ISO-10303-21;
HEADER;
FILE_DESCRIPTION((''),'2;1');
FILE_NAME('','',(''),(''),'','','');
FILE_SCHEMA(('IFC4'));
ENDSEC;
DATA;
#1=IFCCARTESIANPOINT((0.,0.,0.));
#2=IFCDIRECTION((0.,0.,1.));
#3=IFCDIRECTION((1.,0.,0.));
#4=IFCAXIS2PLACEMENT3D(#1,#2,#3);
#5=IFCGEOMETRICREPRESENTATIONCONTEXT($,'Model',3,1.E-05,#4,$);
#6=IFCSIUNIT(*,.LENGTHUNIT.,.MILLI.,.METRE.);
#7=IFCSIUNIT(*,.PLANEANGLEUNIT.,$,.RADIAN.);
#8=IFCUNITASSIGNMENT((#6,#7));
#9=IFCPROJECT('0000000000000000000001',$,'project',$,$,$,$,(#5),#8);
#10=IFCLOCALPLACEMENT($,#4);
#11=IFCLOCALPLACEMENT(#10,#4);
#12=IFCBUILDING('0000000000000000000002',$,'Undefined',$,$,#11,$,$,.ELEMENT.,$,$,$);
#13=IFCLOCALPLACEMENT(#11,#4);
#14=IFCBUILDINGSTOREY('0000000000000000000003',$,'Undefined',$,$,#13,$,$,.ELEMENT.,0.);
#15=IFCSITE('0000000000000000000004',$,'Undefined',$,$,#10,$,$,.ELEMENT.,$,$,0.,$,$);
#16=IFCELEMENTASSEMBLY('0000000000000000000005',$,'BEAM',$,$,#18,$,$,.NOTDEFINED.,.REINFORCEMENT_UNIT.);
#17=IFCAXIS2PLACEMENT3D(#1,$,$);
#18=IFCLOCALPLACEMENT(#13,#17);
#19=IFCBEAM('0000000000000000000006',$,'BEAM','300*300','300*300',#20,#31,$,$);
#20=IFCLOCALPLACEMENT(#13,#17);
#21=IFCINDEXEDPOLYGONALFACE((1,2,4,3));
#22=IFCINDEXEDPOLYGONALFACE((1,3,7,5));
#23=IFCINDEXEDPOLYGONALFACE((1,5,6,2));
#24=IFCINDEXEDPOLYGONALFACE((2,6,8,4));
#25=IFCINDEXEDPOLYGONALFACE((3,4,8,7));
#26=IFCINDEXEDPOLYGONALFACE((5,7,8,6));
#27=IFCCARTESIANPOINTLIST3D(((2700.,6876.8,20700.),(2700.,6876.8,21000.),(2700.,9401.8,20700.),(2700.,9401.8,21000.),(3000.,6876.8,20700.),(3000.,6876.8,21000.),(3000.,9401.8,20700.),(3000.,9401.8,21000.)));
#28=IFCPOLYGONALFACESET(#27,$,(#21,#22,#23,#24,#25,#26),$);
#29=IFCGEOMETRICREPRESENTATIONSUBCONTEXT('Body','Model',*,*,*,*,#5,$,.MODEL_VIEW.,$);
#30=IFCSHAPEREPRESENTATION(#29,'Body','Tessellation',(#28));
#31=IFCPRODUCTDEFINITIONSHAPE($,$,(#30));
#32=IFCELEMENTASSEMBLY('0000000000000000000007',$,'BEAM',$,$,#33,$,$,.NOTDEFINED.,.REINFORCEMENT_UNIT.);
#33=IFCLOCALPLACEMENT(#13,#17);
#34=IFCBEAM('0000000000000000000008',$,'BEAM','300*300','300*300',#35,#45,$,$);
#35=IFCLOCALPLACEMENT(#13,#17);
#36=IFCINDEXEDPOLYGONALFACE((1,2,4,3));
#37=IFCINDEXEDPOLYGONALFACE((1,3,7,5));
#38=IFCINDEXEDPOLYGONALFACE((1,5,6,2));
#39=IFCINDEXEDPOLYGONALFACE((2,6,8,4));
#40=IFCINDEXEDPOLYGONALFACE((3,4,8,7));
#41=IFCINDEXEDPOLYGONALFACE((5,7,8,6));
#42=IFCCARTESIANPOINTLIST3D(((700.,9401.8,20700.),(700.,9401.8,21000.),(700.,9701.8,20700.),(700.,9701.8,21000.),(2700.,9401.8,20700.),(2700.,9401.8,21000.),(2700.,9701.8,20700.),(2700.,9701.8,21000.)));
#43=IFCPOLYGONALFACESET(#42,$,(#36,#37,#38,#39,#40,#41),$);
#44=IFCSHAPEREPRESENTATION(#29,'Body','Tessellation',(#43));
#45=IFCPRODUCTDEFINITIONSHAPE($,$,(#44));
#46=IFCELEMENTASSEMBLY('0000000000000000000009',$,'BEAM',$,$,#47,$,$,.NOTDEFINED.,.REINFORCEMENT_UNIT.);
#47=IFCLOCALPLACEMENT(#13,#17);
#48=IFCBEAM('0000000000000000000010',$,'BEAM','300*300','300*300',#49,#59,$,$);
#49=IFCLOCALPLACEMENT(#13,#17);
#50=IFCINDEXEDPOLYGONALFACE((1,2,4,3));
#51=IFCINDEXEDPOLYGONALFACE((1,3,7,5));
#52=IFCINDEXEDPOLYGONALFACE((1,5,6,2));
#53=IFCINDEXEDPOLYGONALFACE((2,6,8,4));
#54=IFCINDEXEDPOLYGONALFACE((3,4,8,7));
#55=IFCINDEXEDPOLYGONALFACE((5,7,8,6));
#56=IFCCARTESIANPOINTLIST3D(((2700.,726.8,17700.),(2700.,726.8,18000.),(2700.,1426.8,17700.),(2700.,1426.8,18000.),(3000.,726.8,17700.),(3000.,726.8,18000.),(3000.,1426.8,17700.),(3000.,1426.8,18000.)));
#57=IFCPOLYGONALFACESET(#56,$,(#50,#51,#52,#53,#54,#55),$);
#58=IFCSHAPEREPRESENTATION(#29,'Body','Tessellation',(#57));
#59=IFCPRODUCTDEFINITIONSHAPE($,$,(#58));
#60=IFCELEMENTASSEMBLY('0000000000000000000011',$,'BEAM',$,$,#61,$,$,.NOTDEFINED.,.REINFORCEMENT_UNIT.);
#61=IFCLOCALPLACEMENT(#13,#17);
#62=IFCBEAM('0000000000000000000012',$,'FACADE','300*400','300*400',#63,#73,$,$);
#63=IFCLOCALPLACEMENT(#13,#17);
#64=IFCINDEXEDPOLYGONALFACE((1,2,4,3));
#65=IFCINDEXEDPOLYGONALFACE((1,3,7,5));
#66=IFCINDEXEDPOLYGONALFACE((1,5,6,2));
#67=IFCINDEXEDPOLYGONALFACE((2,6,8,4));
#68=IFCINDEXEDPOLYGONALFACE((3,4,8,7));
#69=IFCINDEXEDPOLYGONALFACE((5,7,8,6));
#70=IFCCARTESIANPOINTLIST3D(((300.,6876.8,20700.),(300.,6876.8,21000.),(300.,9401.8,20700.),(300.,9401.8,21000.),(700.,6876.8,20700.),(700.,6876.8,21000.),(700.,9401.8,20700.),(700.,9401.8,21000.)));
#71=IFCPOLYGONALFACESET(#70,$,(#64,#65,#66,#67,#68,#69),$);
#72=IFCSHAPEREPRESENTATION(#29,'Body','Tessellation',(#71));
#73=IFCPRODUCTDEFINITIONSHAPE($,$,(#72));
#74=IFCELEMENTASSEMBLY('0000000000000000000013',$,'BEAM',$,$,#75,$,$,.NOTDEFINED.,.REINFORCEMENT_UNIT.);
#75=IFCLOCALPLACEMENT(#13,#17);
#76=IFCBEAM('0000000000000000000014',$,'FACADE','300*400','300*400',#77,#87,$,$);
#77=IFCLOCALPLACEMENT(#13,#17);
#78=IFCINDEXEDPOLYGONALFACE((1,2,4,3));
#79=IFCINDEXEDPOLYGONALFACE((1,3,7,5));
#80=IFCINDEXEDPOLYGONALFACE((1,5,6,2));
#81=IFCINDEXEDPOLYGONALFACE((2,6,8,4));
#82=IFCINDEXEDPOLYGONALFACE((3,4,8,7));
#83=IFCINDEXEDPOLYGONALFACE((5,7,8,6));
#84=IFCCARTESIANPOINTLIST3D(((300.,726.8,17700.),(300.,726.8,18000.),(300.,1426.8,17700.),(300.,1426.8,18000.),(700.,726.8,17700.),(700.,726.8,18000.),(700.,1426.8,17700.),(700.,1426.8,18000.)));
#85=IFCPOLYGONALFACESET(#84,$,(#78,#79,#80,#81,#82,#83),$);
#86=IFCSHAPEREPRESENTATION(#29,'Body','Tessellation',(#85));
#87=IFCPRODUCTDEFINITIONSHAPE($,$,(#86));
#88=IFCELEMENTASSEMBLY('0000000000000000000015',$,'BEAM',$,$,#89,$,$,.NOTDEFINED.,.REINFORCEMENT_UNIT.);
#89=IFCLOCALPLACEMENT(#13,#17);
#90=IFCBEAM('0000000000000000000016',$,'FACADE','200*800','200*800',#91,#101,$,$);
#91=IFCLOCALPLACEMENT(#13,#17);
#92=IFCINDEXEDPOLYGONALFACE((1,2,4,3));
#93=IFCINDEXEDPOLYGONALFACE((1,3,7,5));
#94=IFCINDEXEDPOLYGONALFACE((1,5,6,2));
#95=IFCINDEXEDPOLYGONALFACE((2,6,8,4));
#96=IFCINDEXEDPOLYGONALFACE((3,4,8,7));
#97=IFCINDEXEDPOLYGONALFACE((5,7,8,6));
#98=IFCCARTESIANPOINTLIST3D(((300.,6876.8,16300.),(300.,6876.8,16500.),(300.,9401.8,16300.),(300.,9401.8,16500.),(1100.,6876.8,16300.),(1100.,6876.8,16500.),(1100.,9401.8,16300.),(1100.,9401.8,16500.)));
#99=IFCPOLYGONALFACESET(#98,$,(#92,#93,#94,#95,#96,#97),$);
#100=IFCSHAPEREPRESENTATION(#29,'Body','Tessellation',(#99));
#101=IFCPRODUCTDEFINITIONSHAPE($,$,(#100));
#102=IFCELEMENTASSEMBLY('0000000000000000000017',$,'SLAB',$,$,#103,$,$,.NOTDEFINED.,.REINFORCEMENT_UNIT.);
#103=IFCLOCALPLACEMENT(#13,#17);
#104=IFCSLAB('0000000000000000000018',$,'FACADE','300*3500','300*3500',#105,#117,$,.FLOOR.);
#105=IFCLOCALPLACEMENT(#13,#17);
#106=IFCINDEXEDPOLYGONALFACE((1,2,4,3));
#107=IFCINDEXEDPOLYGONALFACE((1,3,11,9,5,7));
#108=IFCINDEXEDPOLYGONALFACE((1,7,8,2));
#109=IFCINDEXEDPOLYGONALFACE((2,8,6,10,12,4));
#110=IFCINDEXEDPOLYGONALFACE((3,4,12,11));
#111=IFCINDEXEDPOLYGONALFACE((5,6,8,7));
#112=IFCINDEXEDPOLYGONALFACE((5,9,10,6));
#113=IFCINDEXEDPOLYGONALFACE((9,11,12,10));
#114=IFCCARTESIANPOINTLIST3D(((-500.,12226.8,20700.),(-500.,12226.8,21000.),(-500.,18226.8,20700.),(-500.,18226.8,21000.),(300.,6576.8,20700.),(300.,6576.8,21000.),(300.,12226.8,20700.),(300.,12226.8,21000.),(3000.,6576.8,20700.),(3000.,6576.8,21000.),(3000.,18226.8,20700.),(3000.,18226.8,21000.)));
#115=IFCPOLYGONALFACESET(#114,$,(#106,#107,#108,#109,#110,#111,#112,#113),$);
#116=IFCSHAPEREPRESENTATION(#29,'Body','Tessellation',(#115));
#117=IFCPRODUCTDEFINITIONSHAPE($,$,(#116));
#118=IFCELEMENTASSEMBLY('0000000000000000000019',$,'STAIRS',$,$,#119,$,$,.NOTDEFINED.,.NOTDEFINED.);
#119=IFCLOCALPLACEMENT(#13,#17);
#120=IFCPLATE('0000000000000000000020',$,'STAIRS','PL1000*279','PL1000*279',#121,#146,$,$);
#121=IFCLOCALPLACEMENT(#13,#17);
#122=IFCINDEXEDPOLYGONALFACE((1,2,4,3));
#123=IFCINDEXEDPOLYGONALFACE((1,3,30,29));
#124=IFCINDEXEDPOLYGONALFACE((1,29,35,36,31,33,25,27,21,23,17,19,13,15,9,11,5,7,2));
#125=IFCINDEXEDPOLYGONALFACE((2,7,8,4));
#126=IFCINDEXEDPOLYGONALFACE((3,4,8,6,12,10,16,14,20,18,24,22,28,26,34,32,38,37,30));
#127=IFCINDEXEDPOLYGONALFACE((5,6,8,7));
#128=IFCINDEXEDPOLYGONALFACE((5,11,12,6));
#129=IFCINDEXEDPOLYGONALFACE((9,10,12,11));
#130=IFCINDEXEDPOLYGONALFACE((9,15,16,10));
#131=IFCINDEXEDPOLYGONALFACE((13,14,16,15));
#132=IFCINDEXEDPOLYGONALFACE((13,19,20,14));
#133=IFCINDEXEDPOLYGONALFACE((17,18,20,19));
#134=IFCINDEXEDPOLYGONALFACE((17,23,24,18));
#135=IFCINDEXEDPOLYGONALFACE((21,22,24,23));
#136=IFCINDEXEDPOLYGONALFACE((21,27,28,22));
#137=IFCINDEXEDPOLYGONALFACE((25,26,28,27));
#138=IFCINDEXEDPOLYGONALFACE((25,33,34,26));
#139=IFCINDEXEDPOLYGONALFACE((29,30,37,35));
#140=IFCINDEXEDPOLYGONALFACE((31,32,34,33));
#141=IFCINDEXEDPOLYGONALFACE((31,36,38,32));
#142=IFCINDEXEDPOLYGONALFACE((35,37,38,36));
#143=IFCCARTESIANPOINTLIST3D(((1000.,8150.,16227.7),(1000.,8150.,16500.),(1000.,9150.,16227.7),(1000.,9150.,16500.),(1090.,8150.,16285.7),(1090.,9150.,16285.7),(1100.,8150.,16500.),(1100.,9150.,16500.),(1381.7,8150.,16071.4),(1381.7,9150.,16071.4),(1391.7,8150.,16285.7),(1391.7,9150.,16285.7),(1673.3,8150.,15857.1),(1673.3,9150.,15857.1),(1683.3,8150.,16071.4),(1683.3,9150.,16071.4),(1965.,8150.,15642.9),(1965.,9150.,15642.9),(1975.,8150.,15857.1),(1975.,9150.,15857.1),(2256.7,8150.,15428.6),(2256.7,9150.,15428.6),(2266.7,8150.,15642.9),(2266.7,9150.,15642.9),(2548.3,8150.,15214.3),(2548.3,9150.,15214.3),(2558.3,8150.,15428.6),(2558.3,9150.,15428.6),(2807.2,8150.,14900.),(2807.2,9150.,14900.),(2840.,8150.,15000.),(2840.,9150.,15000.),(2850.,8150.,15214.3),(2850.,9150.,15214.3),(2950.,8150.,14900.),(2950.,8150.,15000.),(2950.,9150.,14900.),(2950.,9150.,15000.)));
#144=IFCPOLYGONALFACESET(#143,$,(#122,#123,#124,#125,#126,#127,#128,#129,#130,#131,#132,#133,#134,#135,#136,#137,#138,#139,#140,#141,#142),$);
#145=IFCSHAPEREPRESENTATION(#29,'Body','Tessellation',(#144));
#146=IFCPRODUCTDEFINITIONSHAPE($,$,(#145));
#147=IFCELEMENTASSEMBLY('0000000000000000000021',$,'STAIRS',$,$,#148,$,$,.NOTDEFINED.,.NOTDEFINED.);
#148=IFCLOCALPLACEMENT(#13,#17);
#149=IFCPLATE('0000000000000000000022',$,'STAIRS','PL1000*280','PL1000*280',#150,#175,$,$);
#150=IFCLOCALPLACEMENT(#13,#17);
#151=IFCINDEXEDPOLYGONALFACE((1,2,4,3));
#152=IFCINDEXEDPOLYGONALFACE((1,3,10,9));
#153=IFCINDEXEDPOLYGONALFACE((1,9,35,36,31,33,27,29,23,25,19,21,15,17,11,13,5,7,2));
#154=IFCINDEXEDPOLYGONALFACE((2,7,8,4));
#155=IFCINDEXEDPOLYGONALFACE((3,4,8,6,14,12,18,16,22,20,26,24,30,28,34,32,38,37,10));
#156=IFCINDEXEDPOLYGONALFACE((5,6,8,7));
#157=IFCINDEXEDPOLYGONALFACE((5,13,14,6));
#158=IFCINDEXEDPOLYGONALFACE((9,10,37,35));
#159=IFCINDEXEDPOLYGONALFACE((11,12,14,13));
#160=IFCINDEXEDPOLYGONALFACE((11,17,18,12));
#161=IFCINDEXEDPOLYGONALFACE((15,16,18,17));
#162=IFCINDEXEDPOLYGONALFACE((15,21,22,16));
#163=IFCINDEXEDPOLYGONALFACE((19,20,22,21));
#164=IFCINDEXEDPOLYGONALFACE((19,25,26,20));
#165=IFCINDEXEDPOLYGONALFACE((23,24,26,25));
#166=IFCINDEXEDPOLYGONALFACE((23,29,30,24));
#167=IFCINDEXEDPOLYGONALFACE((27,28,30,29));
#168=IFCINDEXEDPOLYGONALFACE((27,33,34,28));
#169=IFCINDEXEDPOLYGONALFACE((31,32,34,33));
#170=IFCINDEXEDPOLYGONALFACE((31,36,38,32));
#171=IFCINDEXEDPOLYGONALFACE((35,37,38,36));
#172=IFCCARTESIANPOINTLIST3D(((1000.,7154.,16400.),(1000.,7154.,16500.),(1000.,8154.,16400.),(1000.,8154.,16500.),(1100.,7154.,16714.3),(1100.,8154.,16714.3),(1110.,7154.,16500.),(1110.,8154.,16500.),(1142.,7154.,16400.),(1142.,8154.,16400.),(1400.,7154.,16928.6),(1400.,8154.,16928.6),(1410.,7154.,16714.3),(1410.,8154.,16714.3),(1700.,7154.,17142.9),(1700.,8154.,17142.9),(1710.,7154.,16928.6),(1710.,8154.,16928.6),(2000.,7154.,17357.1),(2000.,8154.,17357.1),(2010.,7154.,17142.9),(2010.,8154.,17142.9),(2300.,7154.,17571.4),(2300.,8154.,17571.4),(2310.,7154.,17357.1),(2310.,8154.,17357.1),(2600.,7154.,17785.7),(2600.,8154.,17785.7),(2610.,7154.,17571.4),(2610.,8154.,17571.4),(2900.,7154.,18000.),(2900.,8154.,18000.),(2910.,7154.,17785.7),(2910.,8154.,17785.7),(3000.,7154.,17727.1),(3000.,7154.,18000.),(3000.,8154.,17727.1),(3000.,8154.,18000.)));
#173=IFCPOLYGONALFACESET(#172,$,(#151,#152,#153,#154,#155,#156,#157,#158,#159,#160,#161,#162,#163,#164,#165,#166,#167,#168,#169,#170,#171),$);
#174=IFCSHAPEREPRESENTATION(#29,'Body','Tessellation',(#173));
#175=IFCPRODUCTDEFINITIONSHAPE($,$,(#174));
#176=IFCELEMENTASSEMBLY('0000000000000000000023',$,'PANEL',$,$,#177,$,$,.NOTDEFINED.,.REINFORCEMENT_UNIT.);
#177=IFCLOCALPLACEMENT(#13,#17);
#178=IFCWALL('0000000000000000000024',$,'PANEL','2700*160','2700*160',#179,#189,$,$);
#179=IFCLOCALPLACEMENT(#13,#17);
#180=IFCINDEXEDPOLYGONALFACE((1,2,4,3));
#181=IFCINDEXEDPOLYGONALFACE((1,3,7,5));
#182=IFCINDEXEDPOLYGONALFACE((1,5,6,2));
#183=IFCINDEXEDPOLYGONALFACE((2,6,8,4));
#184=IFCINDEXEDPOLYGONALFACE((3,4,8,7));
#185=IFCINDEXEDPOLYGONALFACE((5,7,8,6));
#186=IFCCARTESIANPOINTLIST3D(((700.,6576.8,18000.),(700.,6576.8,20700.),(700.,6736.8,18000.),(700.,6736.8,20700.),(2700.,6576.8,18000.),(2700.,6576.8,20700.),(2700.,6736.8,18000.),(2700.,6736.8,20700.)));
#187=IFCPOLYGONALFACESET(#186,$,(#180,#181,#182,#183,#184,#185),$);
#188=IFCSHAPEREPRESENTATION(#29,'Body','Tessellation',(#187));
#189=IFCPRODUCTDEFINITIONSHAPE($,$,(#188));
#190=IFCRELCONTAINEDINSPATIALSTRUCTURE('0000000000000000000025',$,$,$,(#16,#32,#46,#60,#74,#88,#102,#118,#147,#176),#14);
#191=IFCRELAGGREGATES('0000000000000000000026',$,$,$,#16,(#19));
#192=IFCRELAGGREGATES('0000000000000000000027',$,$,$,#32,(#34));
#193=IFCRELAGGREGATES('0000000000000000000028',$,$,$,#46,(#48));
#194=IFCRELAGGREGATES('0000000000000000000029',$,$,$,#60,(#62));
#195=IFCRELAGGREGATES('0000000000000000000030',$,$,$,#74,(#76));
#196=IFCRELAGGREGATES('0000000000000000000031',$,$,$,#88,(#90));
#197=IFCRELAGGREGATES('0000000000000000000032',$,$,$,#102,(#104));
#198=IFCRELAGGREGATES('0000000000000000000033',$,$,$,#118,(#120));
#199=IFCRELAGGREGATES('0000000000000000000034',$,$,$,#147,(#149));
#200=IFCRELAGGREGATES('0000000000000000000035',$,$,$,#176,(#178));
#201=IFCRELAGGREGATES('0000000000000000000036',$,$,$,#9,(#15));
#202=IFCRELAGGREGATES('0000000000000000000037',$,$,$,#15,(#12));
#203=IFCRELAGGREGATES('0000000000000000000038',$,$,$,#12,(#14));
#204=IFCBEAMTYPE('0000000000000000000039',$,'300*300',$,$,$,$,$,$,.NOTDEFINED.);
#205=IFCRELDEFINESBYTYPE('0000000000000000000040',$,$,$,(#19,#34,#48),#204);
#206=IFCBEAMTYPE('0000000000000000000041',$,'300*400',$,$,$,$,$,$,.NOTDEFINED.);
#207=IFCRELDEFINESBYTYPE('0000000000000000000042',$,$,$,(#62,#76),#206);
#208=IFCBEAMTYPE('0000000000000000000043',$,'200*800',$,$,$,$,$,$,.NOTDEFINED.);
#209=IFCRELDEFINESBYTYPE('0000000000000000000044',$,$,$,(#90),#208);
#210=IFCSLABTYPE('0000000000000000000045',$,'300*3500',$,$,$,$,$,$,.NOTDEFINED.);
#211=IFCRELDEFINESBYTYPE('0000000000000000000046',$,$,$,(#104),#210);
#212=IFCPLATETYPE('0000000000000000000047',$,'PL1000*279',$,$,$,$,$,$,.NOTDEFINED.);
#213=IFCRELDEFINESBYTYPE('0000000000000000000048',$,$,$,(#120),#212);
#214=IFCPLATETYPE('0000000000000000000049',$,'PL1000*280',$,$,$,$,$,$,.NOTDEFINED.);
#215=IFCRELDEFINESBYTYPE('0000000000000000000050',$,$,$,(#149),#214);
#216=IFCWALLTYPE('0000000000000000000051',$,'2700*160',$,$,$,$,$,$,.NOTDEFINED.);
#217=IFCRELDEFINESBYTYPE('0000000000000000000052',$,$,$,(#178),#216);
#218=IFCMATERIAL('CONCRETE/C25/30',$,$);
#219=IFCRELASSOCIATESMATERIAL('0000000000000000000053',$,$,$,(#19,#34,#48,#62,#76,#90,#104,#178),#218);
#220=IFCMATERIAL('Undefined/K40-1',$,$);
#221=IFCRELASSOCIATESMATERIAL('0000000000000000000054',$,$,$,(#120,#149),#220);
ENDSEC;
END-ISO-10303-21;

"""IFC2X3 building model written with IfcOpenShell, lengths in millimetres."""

from ifc_helpers import new_model, si_unit, frame, frame_2d, origin_with_axes, origin_2d_with_axis, place, context, subcontext, project, spatial, polyline, rectangle, outline, extrude, material, type_object, element, aggregate, save


model = new_model("IFC2X3")

# Units and contexts
model_context = context("Model", 3, precision=1e-05, world=origin_with_axes())
body_context = subcontext(model_context, "Body", "Model", "MODEL_VIEW")
ifc_project = project(units=[si_unit("LENGTHUNIT", "METRE", prefix="MILLI"), si_unit("PLANEANGLEUNIT", "RADIAN")], contexts=[model_context])

# Site, building, storey
site_placement = place(None, origin_with_axes())
site = spatial("IfcSite", under=ifc_project, at=site_placement, Name="Undefined", CompositionType="ELEMENT", RefElevation=0.0)
building_placement = place(site_placement, origin_with_axes())
building = spatial("IfcBuilding", under=site, at=building_placement, Name="Undefined", CompositionType="ELEMENT")
storey_placement = place(building_placement, origin_with_axes())
storey = spatial("IfcBuildingStorey", under=building, at=storey_placement, Name="Undefined", CompositionType="ELEMENT", Elevation=0.0)

# Shared definitions
ifc_material_1 = material(Name="CONCRETE/C25/30")

# Element assemblies, beams
beam_type_1 = type_object("IfcBeamType", Name="300*300", PredefinedType="NOTDEFINED")
assembly_1_placement = place(storey_placement, origin_with_axes())
assembly_1 = element("IfcElementAssembly", 1, at=assembly_1_placement, inside=storey, Name="BEAM", AssemblyPlace="NOTDEFINED", PredefinedType="REINFORCEMENT_UNIT")
beam_1_placement = place(assembly_1_placement, frame((2850.0, 9401.8, 20850.0), z_axis=(0.0, 0.0, 1.0), x_axis=(0.0, -1.0, 0.0)))
beam_1 = element("IfcBeam", 2, at=beam_1_placement, type_object=beam_type_1, material=ifc_material_1, Name="BEAM", Description="300*300", ObjectType="300*300", context=body_context, shape_type="SweptSolid", body=[
    extrude(rectangle(XDim=300.0, YDim=300.0, at=origin_2d_with_axis()), frame((2525.0, 0.0, 0.0), z_axis=(-1.0, 0.0, 0.0), x_axis=(0.0, -1.0, 0.0)), (0.0, 0.0, 1.0), 2525.0),
])
aggregate(assembly_1, [beam_1])
assembly_2_placement = place(storey_placement, origin_with_axes())
assembly_2 = element("IfcElementAssembly", 3, at=assembly_2_placement, inside=storey, Name="BEAM", AssemblyPlace="NOTDEFINED", PredefinedType="REINFORCEMENT_UNIT")
beam_2_placement = place(assembly_2_placement, frame((2700.0, 9551.8, 20850.0), z_axis=(0.0, 0.0, 1.0), x_axis=(-1.0, 0.0, 0.0)))
beam_2 = element("IfcBeam", 4, at=beam_2_placement, type_object=beam_type_1, material=ifc_material_1, Name="BEAM", Description="300*300", ObjectType="300*300", context=body_context, shape_type="SweptSolid", body=[
    extrude(rectangle(XDim=300.0, YDim=300.0, at=origin_2d_with_axis()), frame((2000.0, 0.0, 0.0), z_axis=(-1.0, 0.0, 0.0), x_axis=(0.0, -1.0, 0.0)), (0.0, 0.0, 1.0), 2000.0),
])
aggregate(assembly_2, [beam_2])
assembly_3_placement = place(storey_placement, origin_with_axes())
assembly_3 = element("IfcElementAssembly", 5, at=assembly_3_placement, inside=storey, Name="BEAM", AssemblyPlace="NOTDEFINED", PredefinedType="REINFORCEMENT_UNIT")
beam_3_placement = place(assembly_3_placement, frame((2850.0, 1426.8, 17850.0), z_axis=(0.0, 0.0, 1.0), x_axis=(0.0, -1.0, 0.0)))
beam_3 = element("IfcBeam", 6, at=beam_3_placement, type_object=beam_type_1, material=ifc_material_1, Name="BEAM", Description="300*300", ObjectType="300*300", context=body_context, shape_type="SweptSolid", body=[
    extrude(rectangle(XDim=300.0, YDim=300.0, at=origin_2d_with_axis()), frame((700.0, 0.0, 0.0), z_axis=(-1.0, 0.0, 0.0), x_axis=(0.0, -1.0, 0.0)), (0.0, 0.0, 1.0), 700.0),
])
aggregate(assembly_3, [beam_3])
assembly_4_placement = place(storey_placement, origin_with_axes())
assembly_4 = element("IfcElementAssembly", 7, at=assembly_4_placement, inside=storey, Name="BEAM", AssemblyPlace="NOTDEFINED", PredefinedType="REINFORCEMENT_UNIT")
beam_type_2 = type_object("IfcBeamType", Name="300*400", PredefinedType="NOTDEFINED")
beam_4_placement = place(assembly_4_placement, frame((500.0, 9401.8, 20850.0), z_axis=(0.0, 0.0, 1.0), x_axis=(0.0, -1.0, 0.0)))
beam_4 = element("IfcBeam", 8, at=beam_4_placement, type_object=beam_type_2, material=ifc_material_1, Name="FACADE", Description="300*400", ObjectType="300*400", context=body_context, shape_type="SweptSolid", body=[
    extrude(rectangle(XDim=400.0, YDim=300.0, at=origin_2d_with_axis()), frame((2525.0, 0.0, 0.0), z_axis=(-1.0, 0.0, 0.0), x_axis=(0.0, -1.0, 0.0)), (0.0, 0.0, 1.0), 2525.0),
])
aggregate(assembly_4, [beam_4])
assembly_5_placement = place(storey_placement, origin_with_axes())
assembly_5 = element("IfcElementAssembly", 9, at=assembly_5_placement, inside=storey, Name="BEAM", AssemblyPlace="NOTDEFINED", PredefinedType="REINFORCEMENT_UNIT")
beam_5_placement = place(assembly_5_placement, frame((500.0, 1426.8, 17850.0), z_axis=(0.0, 0.0, 1.0), x_axis=(0.0, -1.0, 0.0)))
beam_5 = element("IfcBeam", 10, at=beam_5_placement, type_object=beam_type_2, material=ifc_material_1, Name="FACADE", Description="300*400", ObjectType="300*400", context=body_context, shape_type="SweptSolid", body=[
    extrude(rectangle(XDim=400.0, YDim=300.0, at=origin_2d_with_axis()), frame((700.0, 0.0, 0.0), z_axis=(-1.0, 0.0, 0.0), x_axis=(0.0, -1.0, 0.0)), (0.0, 0.0, 1.0), 700.0),
])
aggregate(assembly_5, [beam_5])
assembly_6_placement = place(storey_placement, origin_with_axes())
assembly_6 = element("IfcElementAssembly", 11, at=assembly_6_placement, inside=storey, Name="BEAM", AssemblyPlace="NOTDEFINED", PredefinedType="REINFORCEMENT_UNIT")
beam_type_3 = type_object("IfcBeamType", Name="200*800", PredefinedType="NOTDEFINED")
beam_6_placement = place(assembly_6_placement, frame((700.0, 9401.8, 16400.0), z_axis=(0.0, 0.0, 1.0), x_axis=(0.0, -1.0, 0.0)))
beam_6 = element("IfcBeam", 12, at=beam_6_placement, type_object=beam_type_3, material=ifc_material_1, Name="FACADE", Description="200*800", ObjectType="200*800", context=body_context, shape_type="SweptSolid", body=[
    extrude(rectangle(XDim=800.0, YDim=200.0, at=origin_2d_with_axis()), frame((2525.0, 0.0, 0.0), z_axis=(-1.0, 0.0, 0.0), x_axis=(0.0, -1.0, 0.0)), (0.0, 0.0, 1.0), 2525.0),
])
aggregate(assembly_6, [beam_6])

# Element assembly, slab
assembly_7_placement = place(storey_placement, origin_with_axes())
assembly_7 = element("IfcElementAssembly", 13, at=assembly_7_placement, inside=storey, Name="SLAB", AssemblyPlace="NOTDEFINED", PredefinedType="REINFORCEMENT_UNIT")
slab_type = type_object("IfcSlabType", Name="300*3500", PredefinedType="NOTDEFINED")
slab_placement = place(assembly_7_placement, frame((300.0, 6576.8, 20850.0), z_axis=(0.0, 0.0, 1.0), x_axis=(1.0, 0.0, 0.0)))
slab = element("IfcSlab", 14, at=slab_placement, type_object=slab_type, material=ifc_material_1, Name="FACADE", Description="300*3500", ObjectType="300*3500", PredefinedType="FLOOR", context=body_context, shape_type="SweptSolid", body=[
    extrude(outline(polyline([(0.0, 0.0), (2700.0, 0.0), (2700.0, 11650.0), (-800.0, 11650.0), (-800.0, 5650.0), (0.0, 5650.0), (0.0, 0.0), (0.0, 0.0)])), frame((0.0, 0.0, -150.0), z_axis=(0.0, 0.0, 1.0), x_axis=(1.0, 0.0, 0.0)), (0.0, 0.0, 1.0), 300.0),
])
aggregate(assembly_7, [slab])

# Element assemblies, plates
assembly_8_placement = place(storey_placement, origin_with_axes())
assembly_8 = element("IfcElementAssembly", 15, at=assembly_8_placement, inside=storey, Name="STAIRS", AssemblyPlace="NOTDEFINED", PredefinedType="NOTDEFINED")
ifc_material_2 = material(Name="Undefined/K40-1")
plate_type_1 = type_object("IfcPlateType", Name="PL1000*279", PredefinedType="NOTDEFINED")
plate_1_placement = place(assembly_8_placement, frame((2840.0, 8650.0, 15000.0), z_axis=(0.0, 1.0, 0.0), x_axis=(1.0, 0.0, 0.0)))
plate_1 = element("IfcPlate", 16, at=plate_1_placement, type_object=plate_type_1, material=ifc_material_2, Name="STAIRS", Description="PL1000*279", ObjectType="PL1000*279", context=body_context, shape_type="SweptSolid", body=[
    extrude(outline(polyline([(0.0, 0.0), (110.0, 0.0), (110.0, 100.0), (-32.8, 100.0), (-1840.0, -1227.7), (-1840.0, -1500.0), (-1740.0, -1500.0), (-1750.0, -1285.7), (-1448.3, -1285.7), (-1458.3, -1071.4), (-1156.7, -1071.4), (-1166.7, -857.1), (-865.0, -857.1), (-875.0, -642.9), (-573.3, -642.9), (-583.3, -428.6), (-281.7, -428.6), (-291.7, -214.3), (10.0, -214.3), (0.0, 0.0), (0.0, 0.0)])), frame((0.0, 0.0, -500.0), z_axis=(0.0, 0.0, 1.0), x_axis=(1.0, 0.0, 0.0)), (0.0, 0.0, 1.0), 1000.0),
])
aggregate(assembly_8, [plate_1])
assembly_9_placement = place(storey_placement, origin_with_axes())
assembly_9 = element("IfcElementAssembly", 17, at=assembly_9_placement, inside=storey, Name="STAIRS", AssemblyPlace="NOTDEFINED", PredefinedType="NOTDEFINED")
plate_type_2 = type_object("IfcPlateType", Name="PL1000*280", PredefinedType="NOTDEFINED")
plate_2_placement = place(assembly_9_placement, frame((1110.0, 7654.0, 16500.0), z_axis=(0.0, -1.0, 0.0), x_axis=(-1.0, 0.0, 0.0)))
plate_2 = element("IfcPlate", 18, at=plate_2_placement, type_object=plate_type_2, material=ifc_material_2, Name="STAIRS", Description="PL1000*280", ObjectType="PL1000*280", context=body_context, shape_type="SweptSolid", body=[
    extrude(outline(polyline([(0.0, 0.0), (110.0, 0.0), (110.0, 100.0), (-32.0, 100.0), (-1890.0, -1227.1), (-1890.0, -1500.0), (-1790.0, -1500.0), (-1800.0, -1285.7), (-1490.0, -1285.7), (-1500.0, -1071.4), (-1190.0, -1071.4), (-1200.0, -857.1), (-890.0, -857.1), (-900.0, -642.9), (-590.0, -642.9), (-600.0, -428.6), (-290.0, -428.6), (-300.0, -214.3), (10.0, -214.3), (0.0, 0.0), (0.0, 0.0)])), frame((0.0, 0.0, -500.0), z_axis=(0.0, 0.0, 1.0), x_axis=(1.0, 0.0, 0.0)), (0.0, 0.0, 1.0), 1000.0),
])
aggregate(assembly_9, [plate_2])

# Element assembly, wall
assembly_10_placement = place(storey_placement, origin_with_axes())
assembly_10 = element("IfcElementAssembly", 19, at=assembly_10_placement, inside=storey, Name="PANEL", AssemblyPlace="NOTDEFINED", PredefinedType="REINFORCEMENT_UNIT")
wall_type_1 = type_object("IfcWallType", Name="2700*160", PredefinedType="NOTDEFINED")
wall_1_placement = place(assembly_10_placement, frame((700.0, 6656.8, 18000.0), z_axis=(0.0, 0.0, 1.0), x_axis=(1.0, 0.0, 0.0)))
wall_1 = element("IfcWall", 20, at=wall_1_placement, type_object=wall_type_1, material=ifc_material_1, Name="PANEL", Description="2700*160", ObjectType="2700*160", context=body_context, shape_type="SweptSolid", body=[
    extrude(rectangle(XDim=2000.0, YDim=160.0, at=frame_2d((0.0, 1000.0), x_axis=(0.0, -1.0))), frame((0.0, 0.0, 0.0), z_axis=(0.0, 0.0, 1.0), x_axis=(0.0, -1.0, 0.0)), (0.0, 0.0, 1.0), 2700.0),
])
aggregate(assembly_10, [wall_1])

save(model, "model.ifc")
